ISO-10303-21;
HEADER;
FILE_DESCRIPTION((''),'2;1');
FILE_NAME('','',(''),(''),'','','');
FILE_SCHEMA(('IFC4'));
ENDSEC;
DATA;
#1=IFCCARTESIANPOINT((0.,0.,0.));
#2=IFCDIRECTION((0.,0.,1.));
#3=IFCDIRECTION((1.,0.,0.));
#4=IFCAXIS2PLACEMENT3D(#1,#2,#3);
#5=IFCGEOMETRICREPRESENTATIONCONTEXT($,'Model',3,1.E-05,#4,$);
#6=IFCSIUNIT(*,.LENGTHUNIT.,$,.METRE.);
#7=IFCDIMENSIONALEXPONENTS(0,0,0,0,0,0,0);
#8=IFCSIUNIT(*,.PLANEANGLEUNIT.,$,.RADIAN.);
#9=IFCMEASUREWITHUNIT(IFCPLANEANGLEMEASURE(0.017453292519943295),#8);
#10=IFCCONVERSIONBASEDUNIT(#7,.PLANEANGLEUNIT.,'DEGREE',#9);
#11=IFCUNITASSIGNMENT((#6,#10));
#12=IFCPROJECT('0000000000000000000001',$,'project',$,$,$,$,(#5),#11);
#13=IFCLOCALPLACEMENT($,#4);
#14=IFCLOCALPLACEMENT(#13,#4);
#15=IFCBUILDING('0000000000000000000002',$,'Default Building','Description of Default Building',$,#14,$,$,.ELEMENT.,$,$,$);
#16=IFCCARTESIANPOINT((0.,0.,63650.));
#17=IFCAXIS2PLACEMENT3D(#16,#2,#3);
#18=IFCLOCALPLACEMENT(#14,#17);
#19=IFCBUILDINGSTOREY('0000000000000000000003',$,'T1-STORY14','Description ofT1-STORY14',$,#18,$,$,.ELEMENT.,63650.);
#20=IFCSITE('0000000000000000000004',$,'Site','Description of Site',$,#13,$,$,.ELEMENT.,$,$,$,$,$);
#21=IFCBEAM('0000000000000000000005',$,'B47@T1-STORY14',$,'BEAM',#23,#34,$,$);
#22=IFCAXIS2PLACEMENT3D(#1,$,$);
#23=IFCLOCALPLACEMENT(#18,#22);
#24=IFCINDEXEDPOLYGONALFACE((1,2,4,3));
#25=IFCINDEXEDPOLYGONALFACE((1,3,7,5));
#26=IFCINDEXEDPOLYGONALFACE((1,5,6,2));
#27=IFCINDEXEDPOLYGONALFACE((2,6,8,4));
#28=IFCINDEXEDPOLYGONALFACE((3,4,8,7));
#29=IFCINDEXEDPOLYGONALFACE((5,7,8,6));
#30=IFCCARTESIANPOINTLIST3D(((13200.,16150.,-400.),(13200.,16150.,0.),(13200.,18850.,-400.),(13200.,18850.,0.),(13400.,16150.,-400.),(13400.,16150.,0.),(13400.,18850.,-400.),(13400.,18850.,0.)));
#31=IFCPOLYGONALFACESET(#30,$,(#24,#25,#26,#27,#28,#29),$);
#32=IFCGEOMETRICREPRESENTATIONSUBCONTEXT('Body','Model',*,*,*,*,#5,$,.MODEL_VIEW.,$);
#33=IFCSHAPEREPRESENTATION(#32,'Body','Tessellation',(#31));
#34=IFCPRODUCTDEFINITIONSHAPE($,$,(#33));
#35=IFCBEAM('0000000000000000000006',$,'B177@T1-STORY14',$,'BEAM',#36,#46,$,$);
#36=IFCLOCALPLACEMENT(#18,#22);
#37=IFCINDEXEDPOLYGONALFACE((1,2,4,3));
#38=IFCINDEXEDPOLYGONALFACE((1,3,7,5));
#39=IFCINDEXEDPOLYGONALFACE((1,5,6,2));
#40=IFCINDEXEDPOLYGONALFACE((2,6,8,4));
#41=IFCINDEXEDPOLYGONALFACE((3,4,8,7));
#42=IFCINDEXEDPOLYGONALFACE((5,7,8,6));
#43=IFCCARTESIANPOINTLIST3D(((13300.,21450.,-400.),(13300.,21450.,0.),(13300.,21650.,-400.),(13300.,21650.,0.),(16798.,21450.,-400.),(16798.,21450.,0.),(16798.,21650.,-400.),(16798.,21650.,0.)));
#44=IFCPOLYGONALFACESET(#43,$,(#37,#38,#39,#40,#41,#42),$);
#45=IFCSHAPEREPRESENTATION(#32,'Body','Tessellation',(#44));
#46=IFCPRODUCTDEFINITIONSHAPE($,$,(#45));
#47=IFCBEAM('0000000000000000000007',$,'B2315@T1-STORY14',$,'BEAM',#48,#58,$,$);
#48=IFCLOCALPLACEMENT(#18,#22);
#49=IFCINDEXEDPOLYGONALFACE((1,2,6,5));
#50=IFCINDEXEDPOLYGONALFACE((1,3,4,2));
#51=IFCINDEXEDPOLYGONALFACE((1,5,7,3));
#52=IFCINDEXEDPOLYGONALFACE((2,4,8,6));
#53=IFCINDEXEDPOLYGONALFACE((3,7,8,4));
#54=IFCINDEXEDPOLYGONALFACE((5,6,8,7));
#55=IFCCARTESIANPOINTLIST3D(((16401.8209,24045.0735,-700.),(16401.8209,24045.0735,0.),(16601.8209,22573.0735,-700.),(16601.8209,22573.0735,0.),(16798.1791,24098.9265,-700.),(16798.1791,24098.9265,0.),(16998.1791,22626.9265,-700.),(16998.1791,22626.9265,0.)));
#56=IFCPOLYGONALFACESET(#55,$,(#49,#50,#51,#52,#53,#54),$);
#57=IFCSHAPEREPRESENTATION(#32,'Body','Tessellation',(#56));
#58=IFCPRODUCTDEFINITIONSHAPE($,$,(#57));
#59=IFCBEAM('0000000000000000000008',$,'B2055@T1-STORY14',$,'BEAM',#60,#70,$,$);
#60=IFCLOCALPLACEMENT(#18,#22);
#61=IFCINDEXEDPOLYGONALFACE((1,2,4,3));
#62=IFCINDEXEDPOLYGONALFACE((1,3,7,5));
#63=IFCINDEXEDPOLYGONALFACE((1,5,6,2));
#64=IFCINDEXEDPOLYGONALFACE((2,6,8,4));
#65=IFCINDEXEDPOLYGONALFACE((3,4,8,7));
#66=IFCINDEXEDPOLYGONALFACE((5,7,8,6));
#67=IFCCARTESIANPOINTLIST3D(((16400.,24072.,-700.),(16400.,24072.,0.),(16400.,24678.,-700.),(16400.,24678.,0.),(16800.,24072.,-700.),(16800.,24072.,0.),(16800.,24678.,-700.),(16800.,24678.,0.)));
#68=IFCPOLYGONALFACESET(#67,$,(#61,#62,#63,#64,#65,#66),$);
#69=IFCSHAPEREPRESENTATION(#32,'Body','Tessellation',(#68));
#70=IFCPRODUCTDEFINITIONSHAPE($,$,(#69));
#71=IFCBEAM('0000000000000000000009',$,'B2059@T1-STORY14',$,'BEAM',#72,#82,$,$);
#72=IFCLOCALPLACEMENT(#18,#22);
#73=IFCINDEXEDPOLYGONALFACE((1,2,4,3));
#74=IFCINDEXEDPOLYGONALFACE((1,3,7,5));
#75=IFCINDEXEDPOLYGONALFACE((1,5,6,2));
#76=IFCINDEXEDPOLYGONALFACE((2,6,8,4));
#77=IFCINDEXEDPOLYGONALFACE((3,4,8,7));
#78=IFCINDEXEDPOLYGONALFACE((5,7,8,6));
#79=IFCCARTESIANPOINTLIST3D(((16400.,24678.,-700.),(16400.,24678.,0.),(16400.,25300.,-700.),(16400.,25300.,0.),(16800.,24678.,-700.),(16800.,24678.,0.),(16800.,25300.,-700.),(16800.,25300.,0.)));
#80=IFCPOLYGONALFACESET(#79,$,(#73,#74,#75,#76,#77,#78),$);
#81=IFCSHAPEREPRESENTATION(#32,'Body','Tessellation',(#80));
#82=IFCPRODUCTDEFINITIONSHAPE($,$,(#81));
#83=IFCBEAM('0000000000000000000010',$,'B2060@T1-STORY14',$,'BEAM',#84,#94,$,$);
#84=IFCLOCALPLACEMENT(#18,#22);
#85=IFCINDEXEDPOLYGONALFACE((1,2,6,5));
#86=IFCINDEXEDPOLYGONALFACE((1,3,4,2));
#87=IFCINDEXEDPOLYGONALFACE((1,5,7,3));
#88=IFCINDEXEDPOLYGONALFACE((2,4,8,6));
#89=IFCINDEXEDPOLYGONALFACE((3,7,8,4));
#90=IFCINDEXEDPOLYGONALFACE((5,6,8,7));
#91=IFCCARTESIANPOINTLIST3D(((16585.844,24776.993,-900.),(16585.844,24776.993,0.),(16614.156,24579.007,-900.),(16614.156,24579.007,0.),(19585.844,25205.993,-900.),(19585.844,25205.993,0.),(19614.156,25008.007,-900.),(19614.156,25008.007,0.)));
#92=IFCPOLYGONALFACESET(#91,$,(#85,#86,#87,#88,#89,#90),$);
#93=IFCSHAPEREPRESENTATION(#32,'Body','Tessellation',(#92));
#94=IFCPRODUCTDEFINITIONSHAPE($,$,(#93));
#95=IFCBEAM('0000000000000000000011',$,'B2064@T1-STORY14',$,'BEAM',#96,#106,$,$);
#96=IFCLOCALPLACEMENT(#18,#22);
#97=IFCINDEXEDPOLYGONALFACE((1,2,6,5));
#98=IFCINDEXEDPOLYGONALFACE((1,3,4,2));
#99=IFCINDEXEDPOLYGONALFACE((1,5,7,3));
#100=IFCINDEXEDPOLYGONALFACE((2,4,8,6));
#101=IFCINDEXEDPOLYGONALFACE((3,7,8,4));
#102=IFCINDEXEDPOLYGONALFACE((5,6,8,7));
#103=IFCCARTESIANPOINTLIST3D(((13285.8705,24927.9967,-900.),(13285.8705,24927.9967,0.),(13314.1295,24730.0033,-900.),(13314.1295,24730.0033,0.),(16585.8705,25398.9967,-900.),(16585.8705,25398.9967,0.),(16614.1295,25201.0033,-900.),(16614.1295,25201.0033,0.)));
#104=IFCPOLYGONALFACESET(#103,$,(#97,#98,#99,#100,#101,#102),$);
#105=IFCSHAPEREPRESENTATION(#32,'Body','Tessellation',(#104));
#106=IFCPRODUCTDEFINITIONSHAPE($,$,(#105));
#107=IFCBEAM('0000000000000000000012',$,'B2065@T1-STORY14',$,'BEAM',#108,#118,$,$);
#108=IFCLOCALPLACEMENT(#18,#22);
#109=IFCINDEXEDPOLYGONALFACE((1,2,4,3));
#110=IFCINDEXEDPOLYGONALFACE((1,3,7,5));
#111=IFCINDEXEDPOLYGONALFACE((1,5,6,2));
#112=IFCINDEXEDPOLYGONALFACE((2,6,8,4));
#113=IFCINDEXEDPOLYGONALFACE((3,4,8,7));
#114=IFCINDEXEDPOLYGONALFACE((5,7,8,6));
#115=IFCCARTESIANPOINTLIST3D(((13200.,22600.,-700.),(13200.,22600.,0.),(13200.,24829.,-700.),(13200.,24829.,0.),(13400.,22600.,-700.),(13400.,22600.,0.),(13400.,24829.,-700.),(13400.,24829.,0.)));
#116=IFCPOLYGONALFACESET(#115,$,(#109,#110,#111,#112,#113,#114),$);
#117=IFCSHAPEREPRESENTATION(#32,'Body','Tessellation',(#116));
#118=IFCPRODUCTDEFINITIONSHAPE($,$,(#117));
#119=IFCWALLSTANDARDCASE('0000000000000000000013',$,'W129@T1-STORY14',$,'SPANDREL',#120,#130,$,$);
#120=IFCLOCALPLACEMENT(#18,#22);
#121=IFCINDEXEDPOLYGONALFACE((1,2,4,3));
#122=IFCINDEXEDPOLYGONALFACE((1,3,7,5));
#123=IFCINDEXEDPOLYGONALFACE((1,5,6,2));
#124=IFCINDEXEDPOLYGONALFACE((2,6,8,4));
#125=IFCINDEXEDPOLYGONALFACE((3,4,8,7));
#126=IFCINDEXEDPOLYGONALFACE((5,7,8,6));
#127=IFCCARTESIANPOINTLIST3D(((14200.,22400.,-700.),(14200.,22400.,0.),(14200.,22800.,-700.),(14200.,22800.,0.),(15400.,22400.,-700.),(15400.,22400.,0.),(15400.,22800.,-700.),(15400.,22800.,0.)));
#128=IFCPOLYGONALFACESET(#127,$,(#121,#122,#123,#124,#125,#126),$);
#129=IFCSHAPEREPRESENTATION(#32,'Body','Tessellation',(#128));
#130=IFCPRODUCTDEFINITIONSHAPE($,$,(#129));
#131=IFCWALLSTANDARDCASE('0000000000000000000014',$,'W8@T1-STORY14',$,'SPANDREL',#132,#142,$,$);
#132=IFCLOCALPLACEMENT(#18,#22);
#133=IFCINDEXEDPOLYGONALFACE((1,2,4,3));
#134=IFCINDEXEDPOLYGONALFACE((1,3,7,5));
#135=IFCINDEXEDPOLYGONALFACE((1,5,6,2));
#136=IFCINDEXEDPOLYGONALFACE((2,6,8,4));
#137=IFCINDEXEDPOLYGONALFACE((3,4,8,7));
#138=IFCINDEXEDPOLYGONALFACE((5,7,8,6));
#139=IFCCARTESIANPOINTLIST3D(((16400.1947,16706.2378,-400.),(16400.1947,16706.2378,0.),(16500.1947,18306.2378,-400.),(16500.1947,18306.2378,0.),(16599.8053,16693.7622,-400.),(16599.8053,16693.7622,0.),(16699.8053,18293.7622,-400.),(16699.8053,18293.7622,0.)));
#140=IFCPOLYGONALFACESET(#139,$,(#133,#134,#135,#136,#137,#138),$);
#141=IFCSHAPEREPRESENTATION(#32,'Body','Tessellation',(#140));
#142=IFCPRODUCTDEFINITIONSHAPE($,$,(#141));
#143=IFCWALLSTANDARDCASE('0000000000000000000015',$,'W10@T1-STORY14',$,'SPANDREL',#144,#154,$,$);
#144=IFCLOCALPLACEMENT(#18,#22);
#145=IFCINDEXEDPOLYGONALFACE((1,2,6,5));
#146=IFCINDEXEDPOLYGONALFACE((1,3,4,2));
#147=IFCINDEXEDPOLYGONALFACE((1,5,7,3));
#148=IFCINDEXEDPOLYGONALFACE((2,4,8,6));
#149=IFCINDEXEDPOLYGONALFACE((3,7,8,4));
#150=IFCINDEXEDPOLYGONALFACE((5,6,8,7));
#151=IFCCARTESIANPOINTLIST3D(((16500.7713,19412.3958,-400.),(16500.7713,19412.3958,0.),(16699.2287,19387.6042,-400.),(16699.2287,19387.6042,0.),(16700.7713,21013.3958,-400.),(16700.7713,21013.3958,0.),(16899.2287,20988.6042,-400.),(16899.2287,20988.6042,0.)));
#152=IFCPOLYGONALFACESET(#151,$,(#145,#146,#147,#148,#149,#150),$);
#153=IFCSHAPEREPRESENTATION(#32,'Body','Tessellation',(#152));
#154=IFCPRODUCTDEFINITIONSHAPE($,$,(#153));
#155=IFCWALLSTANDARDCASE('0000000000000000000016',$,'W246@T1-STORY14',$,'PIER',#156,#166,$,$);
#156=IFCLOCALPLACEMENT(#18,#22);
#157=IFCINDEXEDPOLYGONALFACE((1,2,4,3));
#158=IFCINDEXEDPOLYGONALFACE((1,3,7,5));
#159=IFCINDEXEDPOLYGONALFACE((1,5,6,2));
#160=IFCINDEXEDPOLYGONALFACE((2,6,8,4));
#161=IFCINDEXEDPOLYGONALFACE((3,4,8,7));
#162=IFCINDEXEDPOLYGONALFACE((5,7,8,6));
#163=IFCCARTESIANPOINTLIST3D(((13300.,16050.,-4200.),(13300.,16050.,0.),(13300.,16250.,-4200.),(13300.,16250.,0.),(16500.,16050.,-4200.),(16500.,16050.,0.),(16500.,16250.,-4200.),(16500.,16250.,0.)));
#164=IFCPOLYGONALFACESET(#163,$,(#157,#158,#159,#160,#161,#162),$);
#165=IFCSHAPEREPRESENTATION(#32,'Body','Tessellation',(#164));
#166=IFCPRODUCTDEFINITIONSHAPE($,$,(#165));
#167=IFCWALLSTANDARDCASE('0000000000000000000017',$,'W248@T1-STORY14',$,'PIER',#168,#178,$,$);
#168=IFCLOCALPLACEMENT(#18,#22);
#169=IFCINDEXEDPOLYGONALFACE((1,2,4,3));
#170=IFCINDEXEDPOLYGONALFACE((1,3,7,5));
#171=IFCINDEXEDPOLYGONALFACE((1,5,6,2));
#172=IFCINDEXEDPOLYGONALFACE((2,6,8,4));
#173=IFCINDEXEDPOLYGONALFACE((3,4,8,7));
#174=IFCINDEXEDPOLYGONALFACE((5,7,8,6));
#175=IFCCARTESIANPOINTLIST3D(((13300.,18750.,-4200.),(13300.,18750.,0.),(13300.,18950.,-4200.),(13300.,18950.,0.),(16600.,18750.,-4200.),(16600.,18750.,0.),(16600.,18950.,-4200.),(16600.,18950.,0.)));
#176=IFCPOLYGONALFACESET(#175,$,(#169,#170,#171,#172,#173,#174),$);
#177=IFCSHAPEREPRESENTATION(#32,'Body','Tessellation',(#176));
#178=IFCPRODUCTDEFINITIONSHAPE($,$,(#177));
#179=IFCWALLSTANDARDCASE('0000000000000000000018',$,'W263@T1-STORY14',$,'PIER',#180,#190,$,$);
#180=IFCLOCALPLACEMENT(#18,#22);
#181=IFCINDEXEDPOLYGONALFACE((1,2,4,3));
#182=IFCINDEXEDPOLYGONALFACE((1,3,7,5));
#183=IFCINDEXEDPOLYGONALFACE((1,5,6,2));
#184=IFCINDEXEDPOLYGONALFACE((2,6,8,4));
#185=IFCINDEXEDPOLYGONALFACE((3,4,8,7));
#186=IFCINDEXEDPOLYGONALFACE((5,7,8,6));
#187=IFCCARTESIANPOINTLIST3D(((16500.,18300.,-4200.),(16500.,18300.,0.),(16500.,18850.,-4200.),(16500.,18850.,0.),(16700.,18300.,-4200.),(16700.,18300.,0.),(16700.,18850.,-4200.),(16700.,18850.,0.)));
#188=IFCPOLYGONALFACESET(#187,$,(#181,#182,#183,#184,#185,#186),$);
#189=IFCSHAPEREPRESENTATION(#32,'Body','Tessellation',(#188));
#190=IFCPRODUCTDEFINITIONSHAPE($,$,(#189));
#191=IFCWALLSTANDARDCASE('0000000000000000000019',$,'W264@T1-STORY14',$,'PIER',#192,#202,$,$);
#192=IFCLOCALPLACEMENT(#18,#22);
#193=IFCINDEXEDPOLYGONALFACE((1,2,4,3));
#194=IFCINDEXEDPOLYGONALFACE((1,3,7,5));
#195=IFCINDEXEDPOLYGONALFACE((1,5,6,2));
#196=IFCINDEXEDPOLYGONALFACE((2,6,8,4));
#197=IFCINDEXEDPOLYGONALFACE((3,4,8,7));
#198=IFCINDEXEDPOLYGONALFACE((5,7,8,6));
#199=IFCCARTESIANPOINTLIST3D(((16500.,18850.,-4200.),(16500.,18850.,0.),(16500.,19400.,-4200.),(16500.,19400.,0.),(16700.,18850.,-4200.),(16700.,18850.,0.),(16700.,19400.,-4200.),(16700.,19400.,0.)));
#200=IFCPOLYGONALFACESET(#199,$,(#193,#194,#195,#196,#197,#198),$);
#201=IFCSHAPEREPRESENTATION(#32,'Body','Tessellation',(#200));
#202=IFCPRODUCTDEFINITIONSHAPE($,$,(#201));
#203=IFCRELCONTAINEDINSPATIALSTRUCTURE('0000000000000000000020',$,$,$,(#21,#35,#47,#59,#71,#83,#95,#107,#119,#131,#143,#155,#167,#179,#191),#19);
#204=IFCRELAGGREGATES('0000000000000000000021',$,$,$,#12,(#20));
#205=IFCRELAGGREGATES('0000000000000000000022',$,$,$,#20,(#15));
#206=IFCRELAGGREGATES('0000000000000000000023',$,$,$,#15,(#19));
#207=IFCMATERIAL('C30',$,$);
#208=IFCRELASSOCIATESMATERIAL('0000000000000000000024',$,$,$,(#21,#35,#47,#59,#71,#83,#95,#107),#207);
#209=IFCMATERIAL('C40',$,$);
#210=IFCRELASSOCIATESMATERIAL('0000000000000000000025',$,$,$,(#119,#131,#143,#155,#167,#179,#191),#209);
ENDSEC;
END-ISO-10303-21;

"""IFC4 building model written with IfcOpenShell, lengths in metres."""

from ifc_helpers import new_model, entity, si_unit, converted_unit, frame, origin_with_axes, place, context, subcontext, project, spatial, indexed_curve, rectangle, outline, extrude, material, element, save


model = new_model("IFC4")

# Units and contexts
model_context = context("Model", 3, precision=1e-05, world=origin_with_axes())
body_context = subcontext(model_context, "Body", "Model", "MODEL_VIEW")
ifc_project = project(units=[si_unit("LENGTHUNIT", "METRE"), converted_unit("PLANEANGLEUNIT", "DEGREE", entity("IfcPlaneAngleMeasure", 0.017453292519943295), si_unit("PLANEANGLEUNIT", "RADIAN"), dimensions=[0, 0, 0, 0, 0, 0, 0])], contexts=[model_context])

# Site, building, storey
site_placement = place(None, origin_with_axes())
site = spatial("IfcSite", under=ifc_project, at=site_placement, Name="Site", Description="Description of Site", CompositionType="ELEMENT")
building_placement = place(site_placement, origin_with_axes())
building = spatial("IfcBuilding", under=site, at=building_placement, Name="Default Building", Description="Description of Default Building", CompositionType="ELEMENT")
storey_placement = place(building_placement, frame((0.0, 0.0, 63650.0), z_axis=(0.0, 0.0, 1.0), x_axis=(1.0, 0.0, 0.0)))
storey = spatial("IfcBuildingStorey", under=building, at=storey_placement, Name="T1-STORY14", Description="Description ofT1-STORY14", CompositionType="ELEMENT", Elevation=63650.0)

# Beams
ifc_material_1 = material(Name="C30")
beam_1_placement = place(storey_placement, frame((13300.0, 16150.0, -200.0), z_axis=(0.0, 1.0, 0.0), x_axis=(-1.0, 0.0, 0.0)))
element("IfcBeam", 1, at=beam_1_placement, inside=storey, material=ifc_material_1, Name="B47@T1-STORY14", ObjectType="BEAM", context=body_context, shape_type="SweptSolid", body=[
    extrude(rectangle(XDim=200.0, YDim=400.0), origin_with_axes(), (0.0, 0.0, 1.0), 2700.0),
])
beam_2_placement = place(storey_placement, frame((13300.0, 21550.0, -200.0), z_axis=(1.0, 0.0, 0.0), x_axis=(0.0, 1.0, 0.0)))
element("IfcBeam", 2, at=beam_2_placement, inside=storey, material=ifc_material_1, Name="B177@T1-STORY14", ObjectType="BEAM", context=body_context, shape_type="SweptSolid", body=[
    extrude(rectangle(XDim=200.0, YDim=400.0), origin_with_axes(), (0.0, 0.0, 1.0), 3498.0),
])
beam_3_placement = place(storey_placement, frame((16600.0, 24072.0, -350.0), z_axis=(0.134633, -0.990896, 0.0), x_axis=(0.990896, 0.134633, 0.0)))
element("IfcBeam", 3, at=beam_3_placement, inside=storey, material=ifc_material_1, Name="B2315@T1-STORY14", ObjectType="BEAM", context=body_context, shape_type="SweptSolid", body=[
    extrude(rectangle(XDim=400.0, YDim=700.0), origin_with_axes(), (0.0, 0.0, 1.0), 1485.5248),
])
beam_4_placement = place(storey_placement, frame((16600.0, 24072.0, -350.0), z_axis=(0.0, 1.0, 0.0), x_axis=(-1.0, 0.0, 0.0)))
element("IfcBeam", 4, at=beam_4_placement, inside=storey, material=ifc_material_1, Name="B2055@T1-STORY14", ObjectType="BEAM", context=body_context, shape_type="SweptSolid", body=[
    extrude(rectangle(XDim=400.0, YDim=700.0), origin_with_axes(), (0.0, 0.0, 1.0), 606.0),
])
beam_5_placement = place(storey_placement, frame((16600.0, 24678.0, -350.0), z_axis=(0.0, 1.0, 0.0), x_axis=(-1.0, 0.0, 0.0)))
element("IfcBeam", 5, at=beam_5_placement, inside=storey, material=ifc_material_1, Name="B2059@T1-STORY14", ObjectType="BEAM", context=body_context, shape_type="SweptSolid", body=[
    extrude(rectangle(XDim=400.0, YDim=700.0), origin_with_axes(), (0.0, 0.0, 1.0), 622.0),
])
beam_6_placement = place(storey_placement, frame((16600.0, 24678.0, -450.0), z_axis=(0.98993, 0.14156, 0.0), x_axis=(-0.14156, 0.98993, 0.0)))
element("IfcBeam", 6, at=beam_6_placement, inside=storey, material=ifc_material_1, Name="B2060@T1-STORY14", ObjectType="BEAM", context=body_context, shape_type="SweptSolid", body=[
    extrude(rectangle(XDim=200.0, YDim=900.0), origin_with_axes(), (0.0, 0.0, 1.0), 3030.5183),
])
beam_7_placement = place(storey_placement, frame((13300.0, 24829.0, -450.0), z_axis=(0.989967, 0.141295, 0.0), x_axis=(-0.141295, 0.989967, 0.0)))
element("IfcBeam", 7, at=beam_7_placement, inside=storey, material=ifc_material_1, Name="B2064@T1-STORY14", ObjectType="BEAM", context=body_context, shape_type="SweptSolid", body=[
    extrude(rectangle(XDim=200.0, YDim=900.0), origin_with_axes(), (0.0, 0.0, 1.0), 3333.4428),
])
beam_8_placement = place(storey_placement, frame((13300.0, 22600.0, -350.0), z_axis=(0.0, 1.0, 0.0), x_axis=(-1.0, 0.0, 0.0)))
element("IfcBeam", 8, at=beam_8_placement, inside=storey, material=ifc_material_1, Name="B2065@T1-STORY14", ObjectType="BEAM", context=body_context, shape_type="SweptSolid", body=[
    extrude(rectangle(XDim=200.0, YDim=700.0), origin_with_axes(), (0.0, 0.0, 1.0), 2229.0),
])

# Walls
ifc_material_2 = material(Name="C40")
wall_1_placement = place(storey_placement, frame((14200.0, 22600.0, -700.0), z_axis=(0.0, 0.0, 1.0), x_axis=(1.0, 0.0, 0.0)))
element("IfcWallStandardCase", 9, at=wall_1_placement, inside=storey, material=ifc_material_2, Name="W129@T1-STORY14", ObjectType="SPANDREL", context=body_context, shape_type="SweptSolid", body=[
    extrude(outline(indexed_curve([(0.0, -200.0), (0.0, 200.0), (1200.0, 200.0), (1200.0, -200.0), (0.0, -200.0)], self_intersect=False)), origin_with_axes(), (0.0, 0.0, 1.0), 700.0),
])
wall_2_placement = place(storey_placement, frame((16500.0, 16700.0, -400.0), z_axis=(0.0, 0.0, 1.0), x_axis=(0.062378, 0.998053, 0.0)))
element("IfcWallStandardCase", 10, at=wall_2_placement, inside=storey, material=ifc_material_2, Name="W8@T1-STORY14", ObjectType="SPANDREL", context=body_context, shape_type="SweptSolid", body=[
    extrude(outline(indexed_curve([(0.0, -100.0), (0.0, 100.0), (1603.122, 100.0), (1603.122, -100.0), (0.0, -100.0)], self_intersect=False)), origin_with_axes(), (0.0, 0.0, 1.0), 400.0),
])
wall_3_placement = place(storey_placement, frame((16600.0, 19400.0, -400.0), z_axis=(0.0, 0.0, 1.0), x_axis=(0.123958, 0.992287, 0.0)))
element("IfcWallStandardCase", 11, at=wall_3_placement, inside=storey, material=ifc_material_2, Name="W10@T1-STORY14", ObjectType="SPANDREL", context=body_context, shape_type="SweptSolid", body=[
    extrude(outline(indexed_curve([(0.0, -100.0), (0.0, 100.0), (1613.4438, 100.0), (1613.4438, -100.0), (0.0, -100.0)], self_intersect=False)), origin_with_axes(), (0.0, 0.0, 1.0), 400.0),
])
wall_4_placement = place(storey_placement, frame((13300.0, 16150.0, -4200.0), z_axis=(0.0, 0.0, 1.0), x_axis=(1.0, 0.0, 0.0)))
element("IfcWallStandardCase", 12, at=wall_4_placement, inside=storey, material=ifc_material_2, Name="W246@T1-STORY14", ObjectType="PIER", context=body_context, shape_type="SweptSolid", body=[
    extrude(outline(indexed_curve([(0.0, -100.0), (0.0, 100.0), (3200.0, 100.0), (3200.0, -100.0), (0.0, -100.0)], self_intersect=False)), origin_with_axes(), (0.0, 0.0, 1.0), 4200.0),
])
wall_5_placement = place(storey_placement, frame((13300.0, 18850.0, -4200.0), z_axis=(0.0, 0.0, 1.0), x_axis=(1.0, 0.0, 0.0)))
element("IfcWallStandardCase", 13, at=wall_5_placement, inside=storey, material=ifc_material_2, Name="W248@T1-STORY14", ObjectType="PIER", context=body_context, shape_type="SweptSolid", body=[
    extrude(outline(indexed_curve([(0.0, -100.0), (0.0, 100.0), (3300.0, 100.0), (3300.0, -100.0), (0.0, -100.0)], self_intersect=False)), origin_with_axes(), (0.0, 0.0, 1.0), 4200.0),
])
for number, where, z_axis, x_axis, name in (
    (14, (16600.0, 18300.0, -4200.0), (0.0, 0.0, 1.0), (0.0, 1.0, 0.0), "W263@T1-STORY14"),
    (15, (16600.0, 18850.0, -4200.0), (0.0, 0.0, 1.0), (0.0, 1.0, 0.0), "W264@T1-STORY14"),
):
    element("IfcWallStandardCase", number, at=place(storey_placement, frame(where, z_axis=z_axis, x_axis=x_axis)), inside=storey, material=ifc_material_2, Name=name, ObjectType="PIER", context=body_context, shape_type="SweptSolid", body=[
        extrude(outline(indexed_curve([(0.0, -100.0), (0.0, 100.0), (550.0, 100.0), (550.0, -100.0), (0.0, -100.0)], self_intersect=False)), origin_with_axes(), (0.0, 0.0, 1.0), 4200.0),
    ])

save(model, "model.ifc")
